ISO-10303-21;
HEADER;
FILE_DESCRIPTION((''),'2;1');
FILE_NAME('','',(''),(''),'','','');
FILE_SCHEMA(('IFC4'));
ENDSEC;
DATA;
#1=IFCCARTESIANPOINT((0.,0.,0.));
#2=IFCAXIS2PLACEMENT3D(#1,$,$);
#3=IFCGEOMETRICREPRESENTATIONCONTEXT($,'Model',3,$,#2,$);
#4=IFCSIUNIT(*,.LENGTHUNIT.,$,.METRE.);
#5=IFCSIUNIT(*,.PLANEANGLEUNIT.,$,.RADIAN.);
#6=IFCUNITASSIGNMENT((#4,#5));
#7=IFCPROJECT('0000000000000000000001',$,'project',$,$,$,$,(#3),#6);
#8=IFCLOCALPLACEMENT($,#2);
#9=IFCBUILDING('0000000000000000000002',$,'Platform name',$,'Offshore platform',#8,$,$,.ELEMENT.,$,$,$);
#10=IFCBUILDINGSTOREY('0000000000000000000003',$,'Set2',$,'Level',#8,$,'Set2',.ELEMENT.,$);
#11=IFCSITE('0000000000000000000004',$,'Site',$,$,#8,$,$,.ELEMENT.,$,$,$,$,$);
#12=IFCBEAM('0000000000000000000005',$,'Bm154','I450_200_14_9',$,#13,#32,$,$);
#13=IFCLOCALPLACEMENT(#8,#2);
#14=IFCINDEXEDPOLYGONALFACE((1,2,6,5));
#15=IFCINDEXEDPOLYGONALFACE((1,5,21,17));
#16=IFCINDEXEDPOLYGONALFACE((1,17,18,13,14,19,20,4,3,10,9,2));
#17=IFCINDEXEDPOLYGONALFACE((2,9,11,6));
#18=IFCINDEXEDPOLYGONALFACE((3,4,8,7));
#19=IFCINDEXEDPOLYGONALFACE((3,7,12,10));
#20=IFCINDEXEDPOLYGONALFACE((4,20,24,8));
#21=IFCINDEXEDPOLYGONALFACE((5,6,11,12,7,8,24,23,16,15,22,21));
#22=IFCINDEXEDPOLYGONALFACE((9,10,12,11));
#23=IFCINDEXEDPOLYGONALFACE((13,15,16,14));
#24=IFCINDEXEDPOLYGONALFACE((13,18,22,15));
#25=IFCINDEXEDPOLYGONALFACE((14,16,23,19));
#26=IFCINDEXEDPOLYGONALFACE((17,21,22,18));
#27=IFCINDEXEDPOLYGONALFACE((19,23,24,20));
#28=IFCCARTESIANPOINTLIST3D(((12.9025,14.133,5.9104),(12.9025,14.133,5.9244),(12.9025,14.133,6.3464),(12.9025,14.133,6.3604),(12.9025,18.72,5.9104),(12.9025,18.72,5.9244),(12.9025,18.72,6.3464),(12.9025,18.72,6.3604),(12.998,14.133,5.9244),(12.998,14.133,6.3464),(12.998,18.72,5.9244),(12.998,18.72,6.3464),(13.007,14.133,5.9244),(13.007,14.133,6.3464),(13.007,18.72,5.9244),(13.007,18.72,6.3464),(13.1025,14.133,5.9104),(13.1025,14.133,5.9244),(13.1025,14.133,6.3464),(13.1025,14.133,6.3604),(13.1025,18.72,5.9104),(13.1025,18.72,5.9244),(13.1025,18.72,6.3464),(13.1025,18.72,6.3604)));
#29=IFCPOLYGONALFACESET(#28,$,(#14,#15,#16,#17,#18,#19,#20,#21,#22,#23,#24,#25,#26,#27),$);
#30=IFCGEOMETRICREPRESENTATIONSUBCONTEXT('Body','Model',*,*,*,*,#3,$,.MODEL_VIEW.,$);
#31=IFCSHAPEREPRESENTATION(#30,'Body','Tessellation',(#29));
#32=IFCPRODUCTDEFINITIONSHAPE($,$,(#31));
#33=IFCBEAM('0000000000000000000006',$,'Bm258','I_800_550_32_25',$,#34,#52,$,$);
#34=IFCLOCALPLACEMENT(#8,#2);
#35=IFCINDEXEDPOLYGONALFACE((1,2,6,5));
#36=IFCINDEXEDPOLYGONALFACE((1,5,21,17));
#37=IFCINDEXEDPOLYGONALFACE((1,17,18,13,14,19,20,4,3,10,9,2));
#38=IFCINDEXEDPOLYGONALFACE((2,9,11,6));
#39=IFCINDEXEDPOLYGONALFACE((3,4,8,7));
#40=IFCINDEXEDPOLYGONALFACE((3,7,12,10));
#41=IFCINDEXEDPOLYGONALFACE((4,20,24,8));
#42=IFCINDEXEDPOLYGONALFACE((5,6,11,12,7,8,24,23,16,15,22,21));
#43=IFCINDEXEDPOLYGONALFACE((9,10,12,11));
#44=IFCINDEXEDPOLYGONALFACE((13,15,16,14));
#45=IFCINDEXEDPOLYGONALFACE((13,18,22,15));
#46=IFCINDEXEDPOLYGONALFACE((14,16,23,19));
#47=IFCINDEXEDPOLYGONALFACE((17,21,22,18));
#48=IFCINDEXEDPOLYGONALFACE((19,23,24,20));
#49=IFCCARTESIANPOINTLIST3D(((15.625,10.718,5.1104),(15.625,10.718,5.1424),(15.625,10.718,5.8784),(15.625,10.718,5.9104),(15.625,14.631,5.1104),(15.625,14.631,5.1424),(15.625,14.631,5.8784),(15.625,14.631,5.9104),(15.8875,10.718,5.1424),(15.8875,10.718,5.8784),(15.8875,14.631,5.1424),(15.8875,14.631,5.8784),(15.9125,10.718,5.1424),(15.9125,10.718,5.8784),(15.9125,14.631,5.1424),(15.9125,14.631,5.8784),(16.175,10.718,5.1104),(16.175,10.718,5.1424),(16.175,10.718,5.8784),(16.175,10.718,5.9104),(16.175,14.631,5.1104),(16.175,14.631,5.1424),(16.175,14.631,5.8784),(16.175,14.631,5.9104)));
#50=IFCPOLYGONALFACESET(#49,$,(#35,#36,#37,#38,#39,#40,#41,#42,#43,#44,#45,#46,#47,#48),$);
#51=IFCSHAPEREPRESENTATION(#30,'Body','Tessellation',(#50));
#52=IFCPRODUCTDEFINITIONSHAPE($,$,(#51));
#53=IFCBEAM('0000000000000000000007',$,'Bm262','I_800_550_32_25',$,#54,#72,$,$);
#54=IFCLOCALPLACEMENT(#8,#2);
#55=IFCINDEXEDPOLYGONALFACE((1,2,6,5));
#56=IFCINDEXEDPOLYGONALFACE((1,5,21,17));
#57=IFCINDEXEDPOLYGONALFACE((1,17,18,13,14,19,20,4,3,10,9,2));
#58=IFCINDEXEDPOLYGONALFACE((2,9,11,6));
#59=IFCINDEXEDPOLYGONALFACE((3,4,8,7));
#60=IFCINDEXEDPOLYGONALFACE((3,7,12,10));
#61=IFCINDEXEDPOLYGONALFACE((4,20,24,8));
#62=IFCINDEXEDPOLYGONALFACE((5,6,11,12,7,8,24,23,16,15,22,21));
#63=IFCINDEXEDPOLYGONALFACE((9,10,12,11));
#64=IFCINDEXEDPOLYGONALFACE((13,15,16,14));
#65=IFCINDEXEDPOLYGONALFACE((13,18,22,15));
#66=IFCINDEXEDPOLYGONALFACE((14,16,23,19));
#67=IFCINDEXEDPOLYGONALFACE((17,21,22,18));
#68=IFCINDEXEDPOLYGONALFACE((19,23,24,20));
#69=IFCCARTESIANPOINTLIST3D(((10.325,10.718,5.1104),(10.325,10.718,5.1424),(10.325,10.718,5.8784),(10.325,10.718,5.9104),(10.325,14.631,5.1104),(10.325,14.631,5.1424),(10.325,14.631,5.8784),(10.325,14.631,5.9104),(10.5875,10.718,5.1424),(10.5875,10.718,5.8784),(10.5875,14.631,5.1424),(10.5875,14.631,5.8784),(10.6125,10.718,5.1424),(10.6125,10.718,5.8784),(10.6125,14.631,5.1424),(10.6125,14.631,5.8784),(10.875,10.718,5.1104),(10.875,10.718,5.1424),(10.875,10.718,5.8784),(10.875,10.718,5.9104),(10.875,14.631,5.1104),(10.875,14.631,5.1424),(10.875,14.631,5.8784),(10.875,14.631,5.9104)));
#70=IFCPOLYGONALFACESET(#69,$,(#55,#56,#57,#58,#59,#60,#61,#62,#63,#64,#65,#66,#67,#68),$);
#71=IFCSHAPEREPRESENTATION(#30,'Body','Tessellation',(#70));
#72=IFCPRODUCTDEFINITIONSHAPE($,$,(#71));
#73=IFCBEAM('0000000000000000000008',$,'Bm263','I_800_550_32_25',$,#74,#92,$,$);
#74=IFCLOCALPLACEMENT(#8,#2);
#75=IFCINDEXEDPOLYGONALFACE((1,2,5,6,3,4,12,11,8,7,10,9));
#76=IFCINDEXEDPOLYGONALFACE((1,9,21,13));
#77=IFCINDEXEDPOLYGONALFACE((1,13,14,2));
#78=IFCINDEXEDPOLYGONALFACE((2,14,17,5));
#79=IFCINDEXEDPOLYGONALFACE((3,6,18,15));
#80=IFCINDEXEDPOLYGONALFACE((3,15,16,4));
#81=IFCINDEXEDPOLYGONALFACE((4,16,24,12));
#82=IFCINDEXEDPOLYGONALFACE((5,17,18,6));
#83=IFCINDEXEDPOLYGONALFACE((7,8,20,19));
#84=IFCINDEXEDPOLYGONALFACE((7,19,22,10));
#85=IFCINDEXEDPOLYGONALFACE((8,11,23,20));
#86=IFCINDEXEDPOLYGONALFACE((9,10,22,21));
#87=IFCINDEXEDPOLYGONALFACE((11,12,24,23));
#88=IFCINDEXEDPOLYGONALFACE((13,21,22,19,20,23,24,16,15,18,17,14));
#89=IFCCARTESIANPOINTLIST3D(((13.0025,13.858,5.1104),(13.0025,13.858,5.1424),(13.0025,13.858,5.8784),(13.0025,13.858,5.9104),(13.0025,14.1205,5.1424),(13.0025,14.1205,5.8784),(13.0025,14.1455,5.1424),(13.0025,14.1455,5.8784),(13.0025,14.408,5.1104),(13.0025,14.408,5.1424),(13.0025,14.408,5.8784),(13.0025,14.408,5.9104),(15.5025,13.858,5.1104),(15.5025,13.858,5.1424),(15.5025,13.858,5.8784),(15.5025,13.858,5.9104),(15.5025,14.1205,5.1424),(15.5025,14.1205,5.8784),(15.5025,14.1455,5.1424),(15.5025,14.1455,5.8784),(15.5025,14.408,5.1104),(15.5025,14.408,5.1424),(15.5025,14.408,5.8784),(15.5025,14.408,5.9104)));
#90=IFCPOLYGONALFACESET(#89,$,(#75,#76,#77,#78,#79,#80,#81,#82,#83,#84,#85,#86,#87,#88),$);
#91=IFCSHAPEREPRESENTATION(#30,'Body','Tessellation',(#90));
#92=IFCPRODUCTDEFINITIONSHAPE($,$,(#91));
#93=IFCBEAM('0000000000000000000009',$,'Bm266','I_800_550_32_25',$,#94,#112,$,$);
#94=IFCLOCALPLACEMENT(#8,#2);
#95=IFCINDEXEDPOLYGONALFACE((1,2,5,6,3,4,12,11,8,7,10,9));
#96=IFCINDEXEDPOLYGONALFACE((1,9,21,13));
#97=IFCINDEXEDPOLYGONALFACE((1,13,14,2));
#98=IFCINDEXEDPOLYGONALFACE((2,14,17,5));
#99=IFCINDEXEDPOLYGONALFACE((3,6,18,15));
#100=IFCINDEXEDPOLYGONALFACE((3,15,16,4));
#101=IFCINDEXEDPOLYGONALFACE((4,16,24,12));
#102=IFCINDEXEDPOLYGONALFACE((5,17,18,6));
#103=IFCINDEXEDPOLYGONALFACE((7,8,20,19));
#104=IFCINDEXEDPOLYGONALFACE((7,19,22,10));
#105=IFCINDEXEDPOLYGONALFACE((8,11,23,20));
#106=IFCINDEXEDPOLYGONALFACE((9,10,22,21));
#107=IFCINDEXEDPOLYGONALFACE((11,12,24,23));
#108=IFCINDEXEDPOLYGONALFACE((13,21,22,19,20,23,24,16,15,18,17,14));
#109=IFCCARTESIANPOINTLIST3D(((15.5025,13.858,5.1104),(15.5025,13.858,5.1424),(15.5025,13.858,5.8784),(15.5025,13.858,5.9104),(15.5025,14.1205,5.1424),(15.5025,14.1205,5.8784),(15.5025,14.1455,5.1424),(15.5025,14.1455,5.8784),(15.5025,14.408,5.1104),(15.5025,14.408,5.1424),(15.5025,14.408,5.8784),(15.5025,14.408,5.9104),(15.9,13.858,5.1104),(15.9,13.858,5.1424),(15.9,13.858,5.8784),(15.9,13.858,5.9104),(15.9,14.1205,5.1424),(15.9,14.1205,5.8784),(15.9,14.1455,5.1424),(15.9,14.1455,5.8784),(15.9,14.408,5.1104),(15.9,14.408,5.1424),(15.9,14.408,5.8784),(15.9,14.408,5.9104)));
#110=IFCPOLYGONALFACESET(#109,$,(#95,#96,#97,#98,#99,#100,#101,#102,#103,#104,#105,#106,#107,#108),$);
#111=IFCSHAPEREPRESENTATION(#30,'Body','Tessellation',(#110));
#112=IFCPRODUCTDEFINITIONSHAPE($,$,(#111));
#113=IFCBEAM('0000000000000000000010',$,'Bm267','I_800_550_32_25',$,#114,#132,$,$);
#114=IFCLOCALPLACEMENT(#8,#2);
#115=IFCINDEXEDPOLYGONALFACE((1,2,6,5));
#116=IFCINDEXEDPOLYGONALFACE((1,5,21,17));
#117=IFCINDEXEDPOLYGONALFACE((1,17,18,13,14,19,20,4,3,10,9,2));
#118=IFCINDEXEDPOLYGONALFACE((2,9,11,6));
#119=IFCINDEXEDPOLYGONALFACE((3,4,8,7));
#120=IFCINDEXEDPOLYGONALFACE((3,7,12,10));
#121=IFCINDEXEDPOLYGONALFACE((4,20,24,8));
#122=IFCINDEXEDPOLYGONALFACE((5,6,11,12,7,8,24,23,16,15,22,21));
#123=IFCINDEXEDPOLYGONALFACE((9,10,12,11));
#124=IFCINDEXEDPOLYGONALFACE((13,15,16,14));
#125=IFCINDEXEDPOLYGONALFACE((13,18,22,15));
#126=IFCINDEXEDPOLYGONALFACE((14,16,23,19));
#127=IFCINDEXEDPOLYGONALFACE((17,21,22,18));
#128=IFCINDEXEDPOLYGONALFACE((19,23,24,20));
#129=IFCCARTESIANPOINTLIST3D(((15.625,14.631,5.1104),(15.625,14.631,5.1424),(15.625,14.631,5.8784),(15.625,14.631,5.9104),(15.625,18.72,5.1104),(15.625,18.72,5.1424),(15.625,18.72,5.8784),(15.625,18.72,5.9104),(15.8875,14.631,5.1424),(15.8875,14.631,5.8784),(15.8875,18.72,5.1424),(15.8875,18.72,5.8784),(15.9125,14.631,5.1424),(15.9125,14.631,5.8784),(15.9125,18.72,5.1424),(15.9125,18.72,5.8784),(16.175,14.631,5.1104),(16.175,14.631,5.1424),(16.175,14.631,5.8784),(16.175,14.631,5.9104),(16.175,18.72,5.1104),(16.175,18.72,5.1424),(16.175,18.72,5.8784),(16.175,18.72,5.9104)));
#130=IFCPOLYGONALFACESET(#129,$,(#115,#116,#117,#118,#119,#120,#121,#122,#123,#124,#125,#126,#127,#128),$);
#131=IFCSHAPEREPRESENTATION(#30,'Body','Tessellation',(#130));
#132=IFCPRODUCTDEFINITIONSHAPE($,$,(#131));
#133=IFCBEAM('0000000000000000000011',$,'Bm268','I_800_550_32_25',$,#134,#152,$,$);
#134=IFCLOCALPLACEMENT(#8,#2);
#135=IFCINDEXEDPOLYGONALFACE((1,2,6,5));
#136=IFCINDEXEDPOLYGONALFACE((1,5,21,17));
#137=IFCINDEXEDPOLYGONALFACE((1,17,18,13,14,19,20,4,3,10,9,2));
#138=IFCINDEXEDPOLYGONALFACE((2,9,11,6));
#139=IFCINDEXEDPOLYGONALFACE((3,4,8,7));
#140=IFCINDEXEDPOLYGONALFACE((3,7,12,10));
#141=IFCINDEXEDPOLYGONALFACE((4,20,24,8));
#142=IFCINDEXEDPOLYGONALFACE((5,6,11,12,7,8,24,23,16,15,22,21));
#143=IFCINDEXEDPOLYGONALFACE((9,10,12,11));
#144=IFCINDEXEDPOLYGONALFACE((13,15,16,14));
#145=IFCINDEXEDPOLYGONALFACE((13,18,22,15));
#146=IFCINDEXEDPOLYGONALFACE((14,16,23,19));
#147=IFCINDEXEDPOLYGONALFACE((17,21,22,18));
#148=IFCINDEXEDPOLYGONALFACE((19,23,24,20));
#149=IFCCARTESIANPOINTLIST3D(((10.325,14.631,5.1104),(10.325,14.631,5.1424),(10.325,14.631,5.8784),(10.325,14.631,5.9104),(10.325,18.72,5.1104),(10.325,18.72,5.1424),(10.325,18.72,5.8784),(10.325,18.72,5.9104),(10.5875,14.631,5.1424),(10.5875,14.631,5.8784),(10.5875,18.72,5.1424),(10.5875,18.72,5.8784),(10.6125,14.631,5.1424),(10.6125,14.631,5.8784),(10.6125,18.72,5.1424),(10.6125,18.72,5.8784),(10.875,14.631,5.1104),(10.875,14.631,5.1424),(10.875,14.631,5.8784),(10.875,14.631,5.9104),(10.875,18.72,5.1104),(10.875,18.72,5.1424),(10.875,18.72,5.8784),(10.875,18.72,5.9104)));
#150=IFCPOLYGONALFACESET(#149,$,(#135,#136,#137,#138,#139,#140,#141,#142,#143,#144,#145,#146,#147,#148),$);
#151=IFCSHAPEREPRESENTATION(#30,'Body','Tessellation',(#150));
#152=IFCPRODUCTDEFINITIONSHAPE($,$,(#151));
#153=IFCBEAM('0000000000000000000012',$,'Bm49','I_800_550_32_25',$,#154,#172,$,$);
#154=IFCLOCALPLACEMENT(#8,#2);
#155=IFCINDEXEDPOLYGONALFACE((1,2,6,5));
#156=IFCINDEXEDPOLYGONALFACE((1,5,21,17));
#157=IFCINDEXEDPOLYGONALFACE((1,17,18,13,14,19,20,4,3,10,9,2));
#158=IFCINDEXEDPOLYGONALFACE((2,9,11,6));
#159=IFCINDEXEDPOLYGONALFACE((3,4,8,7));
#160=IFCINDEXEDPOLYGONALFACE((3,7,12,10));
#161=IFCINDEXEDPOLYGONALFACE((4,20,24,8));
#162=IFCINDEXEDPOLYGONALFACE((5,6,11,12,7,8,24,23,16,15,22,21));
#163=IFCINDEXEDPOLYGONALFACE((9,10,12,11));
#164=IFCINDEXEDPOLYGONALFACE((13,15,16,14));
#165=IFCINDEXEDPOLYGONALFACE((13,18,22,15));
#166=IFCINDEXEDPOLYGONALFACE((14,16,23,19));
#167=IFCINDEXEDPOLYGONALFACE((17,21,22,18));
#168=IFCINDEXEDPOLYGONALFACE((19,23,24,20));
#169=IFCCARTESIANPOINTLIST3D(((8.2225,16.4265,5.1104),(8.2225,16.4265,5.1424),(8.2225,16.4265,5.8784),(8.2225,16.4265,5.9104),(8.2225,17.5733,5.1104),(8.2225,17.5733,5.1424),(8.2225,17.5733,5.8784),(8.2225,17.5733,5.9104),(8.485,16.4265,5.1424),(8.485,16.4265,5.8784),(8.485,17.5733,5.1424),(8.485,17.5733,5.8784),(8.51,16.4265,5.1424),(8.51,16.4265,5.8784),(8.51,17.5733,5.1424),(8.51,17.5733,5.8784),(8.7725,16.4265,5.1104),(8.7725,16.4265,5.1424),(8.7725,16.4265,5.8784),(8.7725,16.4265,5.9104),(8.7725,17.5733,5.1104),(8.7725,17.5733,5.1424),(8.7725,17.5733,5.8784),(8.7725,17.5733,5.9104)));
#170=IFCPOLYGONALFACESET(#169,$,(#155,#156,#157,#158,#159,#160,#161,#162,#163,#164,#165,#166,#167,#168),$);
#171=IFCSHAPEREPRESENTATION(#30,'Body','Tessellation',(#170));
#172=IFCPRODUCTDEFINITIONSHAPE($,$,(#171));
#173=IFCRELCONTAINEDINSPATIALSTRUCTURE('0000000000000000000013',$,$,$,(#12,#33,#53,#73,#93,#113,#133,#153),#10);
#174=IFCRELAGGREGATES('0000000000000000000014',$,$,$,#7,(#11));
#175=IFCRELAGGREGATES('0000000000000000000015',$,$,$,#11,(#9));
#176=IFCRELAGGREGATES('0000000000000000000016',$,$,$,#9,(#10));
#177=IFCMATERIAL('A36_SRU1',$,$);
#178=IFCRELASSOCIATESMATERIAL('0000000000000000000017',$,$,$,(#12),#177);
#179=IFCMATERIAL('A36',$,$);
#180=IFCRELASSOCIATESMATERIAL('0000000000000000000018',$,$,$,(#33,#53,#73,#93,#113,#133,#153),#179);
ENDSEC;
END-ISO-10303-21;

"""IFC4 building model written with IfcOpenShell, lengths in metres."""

from ifc_helpers import new_model, si_unit, frame, origin, origin_2d, place, context, subcontext, project, spatial, i_section, extrude, source, transform, mapped, material, element, save


model = new_model("IFC4")

# Units and contexts
model_context = context("Model", 3, world=origin())
body_context = subcontext(model_context, "Body", "Model", "MODEL_VIEW")
ifc_project = project(units=[si_unit("LENGTHUNIT", "METRE"), si_unit("PLANEANGLEUNIT", "RADIAN")], contexts=[model_context])

# Site, building, storey
placement_1 = place(None, origin())
site = spatial("IfcSite", under=ifc_project, at=placement_1, Name="Site", CompositionType="ELEMENT")
building = spatial("IfcBuilding", under=site, at=placement_1, Name="Platform name", ObjectType="Offshore platform", CompositionType="ELEMENT")
storey = spatial("IfcBuildingStorey", under=building, at=placement_1, Name="Set2", ObjectType="Level", LongName="Set2", CompositionType="ELEMENT")

# Beams
ifc_material_1 = material(Name="A36")
ifc_material_2 = material(Name="A36_SRU1")
shared_shape_1 = source(origin(), body_context, "Body", "SweptSolid", [
    extrude(i_section(OverallWidth=0.2, OverallDepth=0.45, WebThickness=0.009, FlangeThickness=0.014, FilletRadius=0.0, at=origin_2d()), frame((0.0, 0.0, 0.0), z_axis=(0.0, 1.0, 0.0), x_axis=(-1.0, 0.0, 0.0)), (0.0, 0.0, 1.0), 4.587),
])
placement_2 = place(None, origin())
placement_3 = place(placement_2, origin())
placement_4 = place(placement_3, origin())
beam_1_placement = place(placement_4, frame((13.0025, 14.133, 6.1354)))
element("IfcBeam", 1, at=beam_1_placement, inside=storey, material=ifc_material_2, Name="Bm154", Description="I450_200_14_9", context=body_context, shape_type="MappedRepresentation", body=[
    mapped(shared_shape_1, transform((0.0, 0.0, 0.0), scale=1.0)),
])
shared_shape_2 = source(origin(), body_context, "Body", "SweptSolid", [
    extrude(i_section(OverallWidth=0.55, OverallDepth=0.8, WebThickness=0.025, FlangeThickness=0.032, FilletRadius=0.0, at=origin_2d()), frame((0.0, 0.0, 0.0), z_axis=(0.0, -1.0, 0.0), x_axis=(1.0, 0.0, 0.0)), (0.0, 0.0, 1.0), 3.913),
])
placement_5 = place(None, origin())
placement_6 = place(placement_5, origin())
placement_7 = place(placement_6, origin())
beam_2_placement = place(placement_7, frame((15.9, 14.631, 5.5104)))
element("IfcBeam", 2, at=beam_2_placement, inside=storey, material=ifc_material_1, Name="Bm258", Description="I_800_550_32_25", context=body_context, shape_type="MappedRepresentation", body=[
    mapped(shared_shape_2, transform((0.0, 0.0, 0.0), scale=1.0)),
])
shared_shape_3 = source(origin(), body_context, "Body", "SweptSolid", [
    extrude(i_section(OverallWidth=0.55, OverallDepth=0.8, WebThickness=0.025, FlangeThickness=0.032, FilletRadius=0.0, at=origin_2d()), frame((0.0, 0.0, 0.0), z_axis=(0.0, -1.0, 0.0), x_axis=(1.0, 0.0, 0.0)), (0.0, 0.0, 1.0), 3.913),
])
placement_8 = place(None, origin())
placement_9 = place(placement_8, origin())
placement_10 = place(placement_9, origin())
beam_3_placement = place(placement_10, frame((10.6, 14.631, 5.5104)))
element("IfcBeam", 3, at=beam_3_placement, inside=storey, material=ifc_material_1, Name="Bm262", Description="I_800_550_32_25", context=body_context, shape_type="MappedRepresentation", body=[
    mapped(shared_shape_3, transform((0.0, 0.0, 0.0), scale=1.0)),
])
shared_shape_4 = source(origin(), body_context, "Body", "SweptSolid", [
    extrude(i_section(OverallWidth=0.55, OverallDepth=0.8, WebThickness=0.025, FlangeThickness=0.032, FilletRadius=0.0, at=origin_2d()), frame((0.0, 0.0, 0.0), z_axis=(1.0, 0.0, 0.0), x_axis=(0.0, 1.0, 0.0)), (0.0, 0.0, 1.0), 2.5),
])
placement_11 = place(None, origin())
placement_12 = place(placement_11, origin())
placement_13 = place(placement_12, origin())
beam_4_placement = place(placement_13, frame((13.0025, 14.133, 5.5104)))
element("IfcBeam", 4, at=beam_4_placement, inside=storey, material=ifc_material_1, Name="Bm263", Description="I_800_550_32_25", context=body_context, shape_type="MappedRepresentation", body=[
    mapped(shared_shape_4, transform((0.0, 0.0, 0.0), scale=1.0)),
])
shared_shape_5 = source(origin(), body_context, "Body", "SweptSolid", [
    extrude(i_section(OverallWidth=0.55, OverallDepth=0.8, WebThickness=0.025, FlangeThickness=0.032, FilletRadius=0.0, at=origin_2d()), frame((0.0, 0.0, 0.0), z_axis=(1.0, 0.0, 0.0), x_axis=(0.0, 1.0, 0.0)), (0.0, 0.0, 1.0), 0.3975),
])
placement_14 = place(None, origin())
placement_15 = place(placement_14, origin())
placement_16 = place(placement_15, origin())
beam_5_placement = place(placement_16, frame((15.5025, 14.133, 5.5104)))
element("IfcBeam", 5, at=beam_5_placement, inside=storey, material=ifc_material_1, Name="Bm266", Description="I_800_550_32_25", context=body_context, shape_type="MappedRepresentation", body=[
    mapped(shared_shape_5, transform((0.0, 0.0, 0.0), scale=1.0)),
])
shared_shape_6 = source(origin(), body_context, "Body", "SweptSolid", [
    extrude(i_section(OverallWidth=0.55, OverallDepth=0.8, WebThickness=0.025, FlangeThickness=0.032, FilletRadius=0.0, at=origin_2d()), frame((0.0, 0.0, 0.0), z_axis=(0.0, -1.0, 0.0), x_axis=(1.0, 0.0, 0.0)), (0.0, 0.0, 1.0), 4.089),
])
placement_17 = place(None, origin())
placement_18 = place(placement_17, origin())
placement_19 = place(placement_18, origin())
beam_6_placement = place(placement_19, frame((15.9, 18.72, 5.5104)))
element("IfcBeam", 6, at=beam_6_placement, inside=storey, material=ifc_material_1, Name="Bm267", Description="I_800_550_32_25", context=body_context, shape_type="MappedRepresentation", body=[
    mapped(shared_shape_6, transform((0.0, 0.0, 0.0), scale=1.0)),
])
shared_shape_7 = source(origin(), body_context, "Body", "SweptSolid", [
    extrude(i_section(OverallWidth=0.55, OverallDepth=0.8, WebThickness=0.025, FlangeThickness=0.032, FilletRadius=0.0, at=origin_2d()), frame((0.0, 0.0, 0.0), z_axis=(0.0, -1.0, 0.0), x_axis=(1.0, 0.0, 0.0)), (0.0, 0.0, 1.0), 4.089),
])
placement_20 = place(None, origin())
placement_21 = place(placement_20, origin())
placement_22 = place(placement_21, origin())
beam_7_placement = place(placement_22, frame((10.6, 18.72, 5.5104)))
element("IfcBeam", 7, at=beam_7_placement, inside=storey, material=ifc_material_1, Name="Bm268", Description="I_800_550_32_25", context=body_context, shape_type="MappedRepresentation", body=[
    mapped(shared_shape_7, transform((0.0, 0.0, 0.0), scale=1.0)),
])
shared_shape_8 = source(origin(), body_context, "Body", "SweptSolid", [
    extrude(i_section(OverallWidth=0.55, OverallDepth=0.8, WebThickness=0.025, FlangeThickness=0.032, FilletRadius=0.0, at=origin_2d()), frame((0.0, 0.0, 0.0), z_axis=(0.0, -1.0, 0.0), x_axis=(1.0, 0.0, 0.0)), (0.0, 0.0, 1.0), 1.1467),
])
placement_23 = place(None, origin())
placement_24 = place(placement_23, origin())
placement_25 = place(placement_24, origin())
beam_8_placement = place(placement_25, frame((8.4975, 17.5733, 5.5104)))
element("IfcBeam", 8, at=beam_8_placement, inside=storey, material=ifc_material_1, Name="Bm49", Description="I_800_550_32_25", context=body_context, shape_type="MappedRepresentation", body=[
    mapped(shared_shape_8, transform((0.0, 0.0, 0.0), scale=1.0)),
])

save(model, "model.ifc")
